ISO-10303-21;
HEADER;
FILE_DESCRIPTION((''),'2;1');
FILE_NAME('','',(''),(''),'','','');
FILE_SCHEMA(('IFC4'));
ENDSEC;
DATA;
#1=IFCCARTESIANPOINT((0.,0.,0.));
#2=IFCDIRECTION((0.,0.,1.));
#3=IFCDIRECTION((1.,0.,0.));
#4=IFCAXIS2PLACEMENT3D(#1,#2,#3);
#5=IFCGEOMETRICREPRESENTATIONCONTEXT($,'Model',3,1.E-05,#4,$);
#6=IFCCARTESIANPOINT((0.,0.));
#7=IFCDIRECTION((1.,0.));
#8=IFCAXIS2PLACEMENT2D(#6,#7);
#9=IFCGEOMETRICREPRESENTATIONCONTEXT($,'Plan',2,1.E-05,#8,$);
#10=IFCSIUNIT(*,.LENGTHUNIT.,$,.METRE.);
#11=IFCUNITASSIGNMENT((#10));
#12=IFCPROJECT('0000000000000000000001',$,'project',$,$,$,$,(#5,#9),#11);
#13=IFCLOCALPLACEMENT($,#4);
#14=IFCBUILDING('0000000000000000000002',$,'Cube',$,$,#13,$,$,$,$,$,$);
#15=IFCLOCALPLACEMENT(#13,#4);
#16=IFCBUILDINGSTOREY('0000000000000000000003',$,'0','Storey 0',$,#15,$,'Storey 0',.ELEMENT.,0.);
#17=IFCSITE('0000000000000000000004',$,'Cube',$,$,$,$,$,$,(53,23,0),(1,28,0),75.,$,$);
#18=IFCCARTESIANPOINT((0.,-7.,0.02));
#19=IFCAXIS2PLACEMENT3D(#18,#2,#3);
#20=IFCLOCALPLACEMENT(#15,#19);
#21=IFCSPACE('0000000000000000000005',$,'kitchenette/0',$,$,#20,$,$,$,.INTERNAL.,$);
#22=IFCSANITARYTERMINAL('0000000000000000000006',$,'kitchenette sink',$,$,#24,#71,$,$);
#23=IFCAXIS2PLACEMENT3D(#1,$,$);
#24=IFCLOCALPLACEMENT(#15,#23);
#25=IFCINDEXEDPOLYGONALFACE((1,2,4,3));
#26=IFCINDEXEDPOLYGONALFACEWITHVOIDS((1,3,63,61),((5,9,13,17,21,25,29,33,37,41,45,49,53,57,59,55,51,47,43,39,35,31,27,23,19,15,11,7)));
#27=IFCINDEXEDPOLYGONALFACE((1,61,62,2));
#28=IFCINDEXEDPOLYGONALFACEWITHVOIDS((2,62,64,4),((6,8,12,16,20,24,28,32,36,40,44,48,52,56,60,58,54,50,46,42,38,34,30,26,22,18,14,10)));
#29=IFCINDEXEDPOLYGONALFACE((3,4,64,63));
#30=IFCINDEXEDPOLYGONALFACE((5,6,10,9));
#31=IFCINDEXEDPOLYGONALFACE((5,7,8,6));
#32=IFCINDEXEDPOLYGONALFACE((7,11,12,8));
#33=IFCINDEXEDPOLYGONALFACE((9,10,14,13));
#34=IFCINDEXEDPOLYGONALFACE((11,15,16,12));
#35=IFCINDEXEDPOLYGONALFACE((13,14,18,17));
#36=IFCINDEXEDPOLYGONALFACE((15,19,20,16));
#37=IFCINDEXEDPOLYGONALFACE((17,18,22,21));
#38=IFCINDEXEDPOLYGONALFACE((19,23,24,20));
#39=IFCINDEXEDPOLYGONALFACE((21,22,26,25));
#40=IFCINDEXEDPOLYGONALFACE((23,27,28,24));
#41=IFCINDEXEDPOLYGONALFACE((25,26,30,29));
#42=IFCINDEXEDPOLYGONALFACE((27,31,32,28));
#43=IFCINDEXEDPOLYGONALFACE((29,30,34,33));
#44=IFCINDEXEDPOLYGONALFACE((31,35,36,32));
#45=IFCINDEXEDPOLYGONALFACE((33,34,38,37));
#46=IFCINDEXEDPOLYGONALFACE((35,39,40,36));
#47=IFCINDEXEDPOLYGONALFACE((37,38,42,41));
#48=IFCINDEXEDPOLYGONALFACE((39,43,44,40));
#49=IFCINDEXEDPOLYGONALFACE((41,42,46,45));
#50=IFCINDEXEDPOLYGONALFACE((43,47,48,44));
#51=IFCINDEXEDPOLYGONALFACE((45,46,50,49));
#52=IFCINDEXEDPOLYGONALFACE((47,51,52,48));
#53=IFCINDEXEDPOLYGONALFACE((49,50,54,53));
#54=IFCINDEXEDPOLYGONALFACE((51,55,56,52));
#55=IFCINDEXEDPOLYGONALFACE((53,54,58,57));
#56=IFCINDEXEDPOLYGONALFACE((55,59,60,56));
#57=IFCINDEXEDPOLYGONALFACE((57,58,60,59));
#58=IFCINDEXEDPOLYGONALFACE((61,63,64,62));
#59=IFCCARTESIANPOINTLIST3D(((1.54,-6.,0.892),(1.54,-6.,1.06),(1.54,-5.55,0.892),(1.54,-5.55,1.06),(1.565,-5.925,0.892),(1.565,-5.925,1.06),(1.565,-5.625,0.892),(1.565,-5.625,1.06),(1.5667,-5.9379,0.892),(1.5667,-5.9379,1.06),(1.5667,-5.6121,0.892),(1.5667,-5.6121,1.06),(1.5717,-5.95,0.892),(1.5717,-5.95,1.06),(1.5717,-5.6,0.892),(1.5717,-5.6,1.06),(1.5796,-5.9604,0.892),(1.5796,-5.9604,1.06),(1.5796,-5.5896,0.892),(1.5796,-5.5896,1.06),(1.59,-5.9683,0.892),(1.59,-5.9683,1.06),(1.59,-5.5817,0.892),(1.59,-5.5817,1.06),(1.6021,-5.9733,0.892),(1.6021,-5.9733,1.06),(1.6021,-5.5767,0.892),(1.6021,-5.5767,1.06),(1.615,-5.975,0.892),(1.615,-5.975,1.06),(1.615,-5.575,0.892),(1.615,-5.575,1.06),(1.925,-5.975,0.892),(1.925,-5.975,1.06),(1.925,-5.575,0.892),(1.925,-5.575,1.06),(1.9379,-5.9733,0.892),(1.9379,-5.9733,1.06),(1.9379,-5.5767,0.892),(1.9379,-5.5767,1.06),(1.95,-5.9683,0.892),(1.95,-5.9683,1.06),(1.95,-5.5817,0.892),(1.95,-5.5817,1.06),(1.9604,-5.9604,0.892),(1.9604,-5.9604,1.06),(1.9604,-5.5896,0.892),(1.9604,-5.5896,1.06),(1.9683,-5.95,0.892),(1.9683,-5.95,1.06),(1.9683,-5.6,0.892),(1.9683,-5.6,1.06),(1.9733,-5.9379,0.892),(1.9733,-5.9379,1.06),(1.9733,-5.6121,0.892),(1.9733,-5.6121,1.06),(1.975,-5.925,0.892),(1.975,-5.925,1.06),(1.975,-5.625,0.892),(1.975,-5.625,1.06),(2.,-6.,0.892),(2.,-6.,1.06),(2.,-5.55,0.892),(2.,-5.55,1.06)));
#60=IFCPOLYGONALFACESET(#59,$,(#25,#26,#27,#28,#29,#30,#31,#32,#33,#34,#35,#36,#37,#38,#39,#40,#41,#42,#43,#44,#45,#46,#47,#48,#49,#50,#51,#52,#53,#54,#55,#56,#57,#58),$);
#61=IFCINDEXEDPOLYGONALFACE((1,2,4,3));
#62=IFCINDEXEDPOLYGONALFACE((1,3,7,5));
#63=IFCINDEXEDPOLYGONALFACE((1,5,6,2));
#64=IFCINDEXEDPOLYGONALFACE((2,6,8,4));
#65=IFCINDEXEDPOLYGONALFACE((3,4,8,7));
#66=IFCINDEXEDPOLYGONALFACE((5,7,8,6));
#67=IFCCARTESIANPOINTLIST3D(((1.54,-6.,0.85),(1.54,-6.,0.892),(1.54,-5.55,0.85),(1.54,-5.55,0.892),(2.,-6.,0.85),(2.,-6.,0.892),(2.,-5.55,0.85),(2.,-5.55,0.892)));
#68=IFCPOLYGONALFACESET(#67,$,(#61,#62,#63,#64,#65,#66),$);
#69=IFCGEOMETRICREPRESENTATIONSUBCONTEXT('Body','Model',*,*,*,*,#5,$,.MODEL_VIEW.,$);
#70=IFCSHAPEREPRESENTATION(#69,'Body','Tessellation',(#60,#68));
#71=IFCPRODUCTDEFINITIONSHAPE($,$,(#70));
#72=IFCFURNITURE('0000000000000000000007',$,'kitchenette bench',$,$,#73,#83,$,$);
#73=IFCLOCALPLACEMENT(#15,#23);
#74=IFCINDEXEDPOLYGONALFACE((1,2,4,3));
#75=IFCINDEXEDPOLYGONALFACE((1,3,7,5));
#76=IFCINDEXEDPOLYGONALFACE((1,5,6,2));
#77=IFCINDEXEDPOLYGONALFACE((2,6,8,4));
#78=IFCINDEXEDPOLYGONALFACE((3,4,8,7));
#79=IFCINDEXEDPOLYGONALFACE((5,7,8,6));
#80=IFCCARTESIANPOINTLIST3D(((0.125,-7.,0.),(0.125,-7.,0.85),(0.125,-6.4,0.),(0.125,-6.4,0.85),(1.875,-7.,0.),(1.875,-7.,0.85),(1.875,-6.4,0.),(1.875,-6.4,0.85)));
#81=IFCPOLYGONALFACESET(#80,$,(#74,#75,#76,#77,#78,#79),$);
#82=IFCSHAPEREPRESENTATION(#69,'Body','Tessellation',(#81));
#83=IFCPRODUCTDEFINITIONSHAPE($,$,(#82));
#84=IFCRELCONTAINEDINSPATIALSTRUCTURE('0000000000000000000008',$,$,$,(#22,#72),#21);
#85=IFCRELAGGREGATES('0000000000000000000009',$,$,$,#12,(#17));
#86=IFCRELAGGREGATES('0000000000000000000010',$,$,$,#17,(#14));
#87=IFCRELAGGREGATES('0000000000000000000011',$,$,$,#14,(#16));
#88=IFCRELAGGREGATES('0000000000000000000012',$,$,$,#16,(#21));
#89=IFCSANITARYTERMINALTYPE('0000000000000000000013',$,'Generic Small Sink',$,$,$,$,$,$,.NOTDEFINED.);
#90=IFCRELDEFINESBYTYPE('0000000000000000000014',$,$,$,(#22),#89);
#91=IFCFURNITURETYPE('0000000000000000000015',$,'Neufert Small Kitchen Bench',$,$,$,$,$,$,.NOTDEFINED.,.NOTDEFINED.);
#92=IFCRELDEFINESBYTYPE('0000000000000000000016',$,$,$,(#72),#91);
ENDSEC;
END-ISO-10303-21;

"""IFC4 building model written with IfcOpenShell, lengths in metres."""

from ifc_helpers import new_model, entity, si_unit, frame, origin_with_axes, origin_2d_with_axis, place, context, subcontext, project, spatial, line, indexed_curve, outline, extrude, shape, source, transform, mapped, type_object, type_shapes, element, save


model = new_model("IFC4")

# Units and contexts
model_context = context("Model", 3, precision=1e-05, world=origin_with_axes())
plan_context = context("Plan", 2, precision=1e-05, world=origin_2d_with_axis())
body_context_1 = subcontext(model_context, "Body", "Model", "MODEL_VIEW")
body_context_2 = subcontext(plan_context, "Body", "Plan", "PLAN_VIEW")
ifc_project = project(units=[si_unit("LENGTHUNIT", "METRE")], contexts=[model_context, plan_context])

# Site, building, storey
site = spatial("IfcSite", under=ifc_project, Name="Cube", RefLatitude=(53, 23, 0), RefLongitude=(1, 28, 0), RefElevation=75.0)
building_placement = place(None, origin_with_axes())
building = spatial("IfcBuilding", under=site, at=building_placement, Name="Cube")
storey_placement = place(building_placement, origin_with_axes())
storey = spatial("IfcBuildingStorey", under=building, at=storey_placement, Name="0", Description="Storey 0", LongName="Storey 0", CompositionType="ELEMENT", Elevation=0.0)

# Shared definitions
space_1_placement = place(storey_placement, frame((0.0, -7.0, 0.02), z_axis=(0.0, 0.0, 1.0), x_axis=(1.0, 0.0, 0.0)))
space_1 = spatial("IfcSpace", under=storey, at=space_1_placement, Name="kitchenette/0", PredefinedType="INTERNAL")

# Sanitary terminal
sanitary_terminal_type_1 = type_object("IfcSanitaryTerminalType", Name="Generic Small Sink", PredefinedType="NOTDEFINED")
shared_indexed_poly_curve_1 = entity("IfcIndexedPolyCurve", entity("IfcCartesianPointList2D", [[0.0, 0.0], [0.45, 0.0], [0.45, 0.46], [0.0, 0.46]]), [entity("IfcLineIndex", [1, 2, 3, 4, 1])])
shared_shape_1 = source(origin_with_axes(), body_context_1, "Body", "SweptSolid", [
    entity("IfcExtrudedAreaSolid", entity("IfcArbitraryProfileDefWithVoids", "AREA", None, shared_indexed_poly_curve_1, [entity("IfcIndexedPolyCurve", entity("IfcCartesianPointList2D", [[0.025, 0.075], [0.0396, 0.0396], [0.075, 0.025], [0.375, 0.025], [0.4104, 0.0396], [0.425, 0.075], [0.425, 0.385], [0.4104, 0.4204], [0.375, 0.435], [0.075, 0.435], [0.0396, 0.4204], [0.025, 0.385]]), [entity("IfcLineIndex", [12, 1]), entity("IfcArcIndex", [1, 2, 3]), entity("IfcLineIndex", [3, 4]), entity("IfcArcIndex", [4, 5, 6]), entity("IfcLineIndex", [6, 7]), entity("IfcArcIndex", [7, 8, 9]), entity("IfcLineIndex", [9, 10]), entity("IfcArcIndex", [10, 11, 12]), entity("IfcLineIndex", [12, 1])])]), entity("IfcAxis2Placement3D", entity("IfcCartesianPoint", [-0.225, -0.46, 0.042]), entity("IfcDirection", [0.0, 0.0, 1.0]), entity("IfcDirection", [1.0, 0.0, 0.0])), entity("IfcDirection", [0.0, 0.0, 1.0]), 0.168),
    entity("IfcExtrudedAreaSolid", entity("IfcArbitraryClosedProfileDef", "AREA", None, shared_indexed_poly_curve_1), entity("IfcAxis2Placement3D", entity("IfcCartesianPoint", [-0.225, -0.46, 0.0]), entity("IfcDirection", [0.0, 0.0, 1.0]), entity("IfcDirection", [1.0, 0.0, 0.0])), entity("IfcDirection", [0.0, 0.0, 1.0]), 0.042),
])
shared_shape_2 = source(origin_with_axes(), body_context_2, "Body", "Curve2D", [
    entity("IfcIndexedPolyCurve", entity("IfcCartesianPointList2D", [[-0.225, -0.46], [0.225, -0.46], [0.225, 0.0], [-0.225, 0.0]]), [entity("IfcLineIndex", [1, 2, 3, 4, 1])]),
    entity("IfcIndexedPolyCurve", entity("IfcCartesianPointList2D", [[-0.2, -0.385], [-0.1854, -0.4204], [-0.15, -0.435], [0.15, -0.435], [0.1854, -0.4204], [0.2, -0.385], [0.2, -0.075], [0.1854, -0.0396], [0.15, -0.025], [-0.15, -0.025], [-0.1854, -0.0396], [-0.2, -0.075]]), [entity("IfcLineIndex", [12, 1]), entity("IfcArcIndex", [1, 2, 3]), entity("IfcLineIndex", [3, 4]), entity("IfcArcIndex", [4, 5, 6]), entity("IfcLineIndex", [6, 7]), entity("IfcArcIndex", [7, 8, 9]), entity("IfcLineIndex", [9, 10]), entity("IfcArcIndex", [10, 11, 12]), entity("IfcLineIndex", [12, 1])]),
    entity("IfcCircle", entity("IfcAxis2Placement2D", entity("IfcCartesianPoint", [0.0, -0.125])), 0.025),
    entity("IfcIndexedPolyCurve", entity("IfcCartesianPointList2D", [[0.0, -0.0125], [0.0, -0.1325]])),
])
type_shapes(sanitary_terminal_type_1, [shared_shape_1, shared_shape_2])
sanitary_terminal_1_placement = place(space_1_placement, frame((2.0, 1.225, 0.83), z_axis=(0.0, 0.0, 1.0), x_axis=(0.0, -1.0, 0.0)))
element("IfcSanitaryTerminal", 1, at=sanitary_terminal_1_placement, inside=space_1, type_object=sanitary_terminal_type_1, Name="kitchenette sink", shapes=[
    shape(body_context_1, "Body", "MappedRepresentation", [mapped(shared_shape_1, transform((0.0, 0.0, 0.0), x_axis=(1.0, 0.0, 0.0), y_axis=(0.0, 1.0, 0.0), z_axis=(0.0, 0.0, 1.0), scale=1.0))]),
    shape(body_context_2, "Body", "MappedRepresentation", [mapped(shared_shape_2, transform((0.0, 0.0, 0.0), x_axis=(1.0, 0.0, 0.0), y_axis=(0.0, 1.0, 0.0), z_axis=(0.0, 0.0, 1.0), scale=1.0))]),
])

# Furniture
furniture_type = type_object("IfcFurnitureType", Name="Neufert Small Kitchen Bench", AssemblyPlace="NOTDEFINED", PredefinedType="NOTDEFINED")
shared_shape_3 = source(origin_with_axes(), body_context_1, "Body", "SweptSolid", [
    extrude(outline(indexed_curve([(0.0, 0.0), (1.75, 0.0), (1.75, 0.6), (0.0, 0.6)], segments=[line(1, 2, 3, 4, 1)])), origin_with_axes(), (0.0, 0.0, 1.0), 0.85),
])
shared_shape_4 = source(origin_with_axes(), body_context_2, "Body", "Curve2D", [
    entity("IfcIndexedPolyCurve", entity("IfcCartesianPointList2D", [[0.0, 0.0], [1.75, 0.0], [1.75, 0.6], [0.0, 0.6]]), [entity("IfcLineIndex", [1, 2, 3, 4, 1])]),
])
type_shapes(furniture_type, [shared_shape_3, shared_shape_4])
furniture_placement = place(space_1_placement, frame((0.125, 0.0, -0.02), z_axis=(0.0, 0.0, 1.0), x_axis=(1.0, 0.0, 0.0)))
element("IfcFurniture", 2, at=furniture_placement, inside=space_1, type_object=furniture_type, Name="kitchenette bench", shapes=[
    shape(body_context_1, "Body", "MappedRepresentation", [mapped(shared_shape_3, transform((0.0, 0.0, 0.0), x_axis=(1.0, 0.0, 0.0), y_axis=(0.0, 1.0, 0.0), z_axis=(0.0, 0.0, 1.0), scale=1.0))]),
    shape(body_context_2, "Body", "MappedRepresentation", [mapped(shared_shape_4, transform((0.0, 0.0, 0.0), x_axis=(1.0, 0.0, 0.0), y_axis=(0.0, 1.0, 0.0), z_axis=(0.0, 0.0, 1.0), scale=1.0))]),
])

save(model, "model.ifc")
